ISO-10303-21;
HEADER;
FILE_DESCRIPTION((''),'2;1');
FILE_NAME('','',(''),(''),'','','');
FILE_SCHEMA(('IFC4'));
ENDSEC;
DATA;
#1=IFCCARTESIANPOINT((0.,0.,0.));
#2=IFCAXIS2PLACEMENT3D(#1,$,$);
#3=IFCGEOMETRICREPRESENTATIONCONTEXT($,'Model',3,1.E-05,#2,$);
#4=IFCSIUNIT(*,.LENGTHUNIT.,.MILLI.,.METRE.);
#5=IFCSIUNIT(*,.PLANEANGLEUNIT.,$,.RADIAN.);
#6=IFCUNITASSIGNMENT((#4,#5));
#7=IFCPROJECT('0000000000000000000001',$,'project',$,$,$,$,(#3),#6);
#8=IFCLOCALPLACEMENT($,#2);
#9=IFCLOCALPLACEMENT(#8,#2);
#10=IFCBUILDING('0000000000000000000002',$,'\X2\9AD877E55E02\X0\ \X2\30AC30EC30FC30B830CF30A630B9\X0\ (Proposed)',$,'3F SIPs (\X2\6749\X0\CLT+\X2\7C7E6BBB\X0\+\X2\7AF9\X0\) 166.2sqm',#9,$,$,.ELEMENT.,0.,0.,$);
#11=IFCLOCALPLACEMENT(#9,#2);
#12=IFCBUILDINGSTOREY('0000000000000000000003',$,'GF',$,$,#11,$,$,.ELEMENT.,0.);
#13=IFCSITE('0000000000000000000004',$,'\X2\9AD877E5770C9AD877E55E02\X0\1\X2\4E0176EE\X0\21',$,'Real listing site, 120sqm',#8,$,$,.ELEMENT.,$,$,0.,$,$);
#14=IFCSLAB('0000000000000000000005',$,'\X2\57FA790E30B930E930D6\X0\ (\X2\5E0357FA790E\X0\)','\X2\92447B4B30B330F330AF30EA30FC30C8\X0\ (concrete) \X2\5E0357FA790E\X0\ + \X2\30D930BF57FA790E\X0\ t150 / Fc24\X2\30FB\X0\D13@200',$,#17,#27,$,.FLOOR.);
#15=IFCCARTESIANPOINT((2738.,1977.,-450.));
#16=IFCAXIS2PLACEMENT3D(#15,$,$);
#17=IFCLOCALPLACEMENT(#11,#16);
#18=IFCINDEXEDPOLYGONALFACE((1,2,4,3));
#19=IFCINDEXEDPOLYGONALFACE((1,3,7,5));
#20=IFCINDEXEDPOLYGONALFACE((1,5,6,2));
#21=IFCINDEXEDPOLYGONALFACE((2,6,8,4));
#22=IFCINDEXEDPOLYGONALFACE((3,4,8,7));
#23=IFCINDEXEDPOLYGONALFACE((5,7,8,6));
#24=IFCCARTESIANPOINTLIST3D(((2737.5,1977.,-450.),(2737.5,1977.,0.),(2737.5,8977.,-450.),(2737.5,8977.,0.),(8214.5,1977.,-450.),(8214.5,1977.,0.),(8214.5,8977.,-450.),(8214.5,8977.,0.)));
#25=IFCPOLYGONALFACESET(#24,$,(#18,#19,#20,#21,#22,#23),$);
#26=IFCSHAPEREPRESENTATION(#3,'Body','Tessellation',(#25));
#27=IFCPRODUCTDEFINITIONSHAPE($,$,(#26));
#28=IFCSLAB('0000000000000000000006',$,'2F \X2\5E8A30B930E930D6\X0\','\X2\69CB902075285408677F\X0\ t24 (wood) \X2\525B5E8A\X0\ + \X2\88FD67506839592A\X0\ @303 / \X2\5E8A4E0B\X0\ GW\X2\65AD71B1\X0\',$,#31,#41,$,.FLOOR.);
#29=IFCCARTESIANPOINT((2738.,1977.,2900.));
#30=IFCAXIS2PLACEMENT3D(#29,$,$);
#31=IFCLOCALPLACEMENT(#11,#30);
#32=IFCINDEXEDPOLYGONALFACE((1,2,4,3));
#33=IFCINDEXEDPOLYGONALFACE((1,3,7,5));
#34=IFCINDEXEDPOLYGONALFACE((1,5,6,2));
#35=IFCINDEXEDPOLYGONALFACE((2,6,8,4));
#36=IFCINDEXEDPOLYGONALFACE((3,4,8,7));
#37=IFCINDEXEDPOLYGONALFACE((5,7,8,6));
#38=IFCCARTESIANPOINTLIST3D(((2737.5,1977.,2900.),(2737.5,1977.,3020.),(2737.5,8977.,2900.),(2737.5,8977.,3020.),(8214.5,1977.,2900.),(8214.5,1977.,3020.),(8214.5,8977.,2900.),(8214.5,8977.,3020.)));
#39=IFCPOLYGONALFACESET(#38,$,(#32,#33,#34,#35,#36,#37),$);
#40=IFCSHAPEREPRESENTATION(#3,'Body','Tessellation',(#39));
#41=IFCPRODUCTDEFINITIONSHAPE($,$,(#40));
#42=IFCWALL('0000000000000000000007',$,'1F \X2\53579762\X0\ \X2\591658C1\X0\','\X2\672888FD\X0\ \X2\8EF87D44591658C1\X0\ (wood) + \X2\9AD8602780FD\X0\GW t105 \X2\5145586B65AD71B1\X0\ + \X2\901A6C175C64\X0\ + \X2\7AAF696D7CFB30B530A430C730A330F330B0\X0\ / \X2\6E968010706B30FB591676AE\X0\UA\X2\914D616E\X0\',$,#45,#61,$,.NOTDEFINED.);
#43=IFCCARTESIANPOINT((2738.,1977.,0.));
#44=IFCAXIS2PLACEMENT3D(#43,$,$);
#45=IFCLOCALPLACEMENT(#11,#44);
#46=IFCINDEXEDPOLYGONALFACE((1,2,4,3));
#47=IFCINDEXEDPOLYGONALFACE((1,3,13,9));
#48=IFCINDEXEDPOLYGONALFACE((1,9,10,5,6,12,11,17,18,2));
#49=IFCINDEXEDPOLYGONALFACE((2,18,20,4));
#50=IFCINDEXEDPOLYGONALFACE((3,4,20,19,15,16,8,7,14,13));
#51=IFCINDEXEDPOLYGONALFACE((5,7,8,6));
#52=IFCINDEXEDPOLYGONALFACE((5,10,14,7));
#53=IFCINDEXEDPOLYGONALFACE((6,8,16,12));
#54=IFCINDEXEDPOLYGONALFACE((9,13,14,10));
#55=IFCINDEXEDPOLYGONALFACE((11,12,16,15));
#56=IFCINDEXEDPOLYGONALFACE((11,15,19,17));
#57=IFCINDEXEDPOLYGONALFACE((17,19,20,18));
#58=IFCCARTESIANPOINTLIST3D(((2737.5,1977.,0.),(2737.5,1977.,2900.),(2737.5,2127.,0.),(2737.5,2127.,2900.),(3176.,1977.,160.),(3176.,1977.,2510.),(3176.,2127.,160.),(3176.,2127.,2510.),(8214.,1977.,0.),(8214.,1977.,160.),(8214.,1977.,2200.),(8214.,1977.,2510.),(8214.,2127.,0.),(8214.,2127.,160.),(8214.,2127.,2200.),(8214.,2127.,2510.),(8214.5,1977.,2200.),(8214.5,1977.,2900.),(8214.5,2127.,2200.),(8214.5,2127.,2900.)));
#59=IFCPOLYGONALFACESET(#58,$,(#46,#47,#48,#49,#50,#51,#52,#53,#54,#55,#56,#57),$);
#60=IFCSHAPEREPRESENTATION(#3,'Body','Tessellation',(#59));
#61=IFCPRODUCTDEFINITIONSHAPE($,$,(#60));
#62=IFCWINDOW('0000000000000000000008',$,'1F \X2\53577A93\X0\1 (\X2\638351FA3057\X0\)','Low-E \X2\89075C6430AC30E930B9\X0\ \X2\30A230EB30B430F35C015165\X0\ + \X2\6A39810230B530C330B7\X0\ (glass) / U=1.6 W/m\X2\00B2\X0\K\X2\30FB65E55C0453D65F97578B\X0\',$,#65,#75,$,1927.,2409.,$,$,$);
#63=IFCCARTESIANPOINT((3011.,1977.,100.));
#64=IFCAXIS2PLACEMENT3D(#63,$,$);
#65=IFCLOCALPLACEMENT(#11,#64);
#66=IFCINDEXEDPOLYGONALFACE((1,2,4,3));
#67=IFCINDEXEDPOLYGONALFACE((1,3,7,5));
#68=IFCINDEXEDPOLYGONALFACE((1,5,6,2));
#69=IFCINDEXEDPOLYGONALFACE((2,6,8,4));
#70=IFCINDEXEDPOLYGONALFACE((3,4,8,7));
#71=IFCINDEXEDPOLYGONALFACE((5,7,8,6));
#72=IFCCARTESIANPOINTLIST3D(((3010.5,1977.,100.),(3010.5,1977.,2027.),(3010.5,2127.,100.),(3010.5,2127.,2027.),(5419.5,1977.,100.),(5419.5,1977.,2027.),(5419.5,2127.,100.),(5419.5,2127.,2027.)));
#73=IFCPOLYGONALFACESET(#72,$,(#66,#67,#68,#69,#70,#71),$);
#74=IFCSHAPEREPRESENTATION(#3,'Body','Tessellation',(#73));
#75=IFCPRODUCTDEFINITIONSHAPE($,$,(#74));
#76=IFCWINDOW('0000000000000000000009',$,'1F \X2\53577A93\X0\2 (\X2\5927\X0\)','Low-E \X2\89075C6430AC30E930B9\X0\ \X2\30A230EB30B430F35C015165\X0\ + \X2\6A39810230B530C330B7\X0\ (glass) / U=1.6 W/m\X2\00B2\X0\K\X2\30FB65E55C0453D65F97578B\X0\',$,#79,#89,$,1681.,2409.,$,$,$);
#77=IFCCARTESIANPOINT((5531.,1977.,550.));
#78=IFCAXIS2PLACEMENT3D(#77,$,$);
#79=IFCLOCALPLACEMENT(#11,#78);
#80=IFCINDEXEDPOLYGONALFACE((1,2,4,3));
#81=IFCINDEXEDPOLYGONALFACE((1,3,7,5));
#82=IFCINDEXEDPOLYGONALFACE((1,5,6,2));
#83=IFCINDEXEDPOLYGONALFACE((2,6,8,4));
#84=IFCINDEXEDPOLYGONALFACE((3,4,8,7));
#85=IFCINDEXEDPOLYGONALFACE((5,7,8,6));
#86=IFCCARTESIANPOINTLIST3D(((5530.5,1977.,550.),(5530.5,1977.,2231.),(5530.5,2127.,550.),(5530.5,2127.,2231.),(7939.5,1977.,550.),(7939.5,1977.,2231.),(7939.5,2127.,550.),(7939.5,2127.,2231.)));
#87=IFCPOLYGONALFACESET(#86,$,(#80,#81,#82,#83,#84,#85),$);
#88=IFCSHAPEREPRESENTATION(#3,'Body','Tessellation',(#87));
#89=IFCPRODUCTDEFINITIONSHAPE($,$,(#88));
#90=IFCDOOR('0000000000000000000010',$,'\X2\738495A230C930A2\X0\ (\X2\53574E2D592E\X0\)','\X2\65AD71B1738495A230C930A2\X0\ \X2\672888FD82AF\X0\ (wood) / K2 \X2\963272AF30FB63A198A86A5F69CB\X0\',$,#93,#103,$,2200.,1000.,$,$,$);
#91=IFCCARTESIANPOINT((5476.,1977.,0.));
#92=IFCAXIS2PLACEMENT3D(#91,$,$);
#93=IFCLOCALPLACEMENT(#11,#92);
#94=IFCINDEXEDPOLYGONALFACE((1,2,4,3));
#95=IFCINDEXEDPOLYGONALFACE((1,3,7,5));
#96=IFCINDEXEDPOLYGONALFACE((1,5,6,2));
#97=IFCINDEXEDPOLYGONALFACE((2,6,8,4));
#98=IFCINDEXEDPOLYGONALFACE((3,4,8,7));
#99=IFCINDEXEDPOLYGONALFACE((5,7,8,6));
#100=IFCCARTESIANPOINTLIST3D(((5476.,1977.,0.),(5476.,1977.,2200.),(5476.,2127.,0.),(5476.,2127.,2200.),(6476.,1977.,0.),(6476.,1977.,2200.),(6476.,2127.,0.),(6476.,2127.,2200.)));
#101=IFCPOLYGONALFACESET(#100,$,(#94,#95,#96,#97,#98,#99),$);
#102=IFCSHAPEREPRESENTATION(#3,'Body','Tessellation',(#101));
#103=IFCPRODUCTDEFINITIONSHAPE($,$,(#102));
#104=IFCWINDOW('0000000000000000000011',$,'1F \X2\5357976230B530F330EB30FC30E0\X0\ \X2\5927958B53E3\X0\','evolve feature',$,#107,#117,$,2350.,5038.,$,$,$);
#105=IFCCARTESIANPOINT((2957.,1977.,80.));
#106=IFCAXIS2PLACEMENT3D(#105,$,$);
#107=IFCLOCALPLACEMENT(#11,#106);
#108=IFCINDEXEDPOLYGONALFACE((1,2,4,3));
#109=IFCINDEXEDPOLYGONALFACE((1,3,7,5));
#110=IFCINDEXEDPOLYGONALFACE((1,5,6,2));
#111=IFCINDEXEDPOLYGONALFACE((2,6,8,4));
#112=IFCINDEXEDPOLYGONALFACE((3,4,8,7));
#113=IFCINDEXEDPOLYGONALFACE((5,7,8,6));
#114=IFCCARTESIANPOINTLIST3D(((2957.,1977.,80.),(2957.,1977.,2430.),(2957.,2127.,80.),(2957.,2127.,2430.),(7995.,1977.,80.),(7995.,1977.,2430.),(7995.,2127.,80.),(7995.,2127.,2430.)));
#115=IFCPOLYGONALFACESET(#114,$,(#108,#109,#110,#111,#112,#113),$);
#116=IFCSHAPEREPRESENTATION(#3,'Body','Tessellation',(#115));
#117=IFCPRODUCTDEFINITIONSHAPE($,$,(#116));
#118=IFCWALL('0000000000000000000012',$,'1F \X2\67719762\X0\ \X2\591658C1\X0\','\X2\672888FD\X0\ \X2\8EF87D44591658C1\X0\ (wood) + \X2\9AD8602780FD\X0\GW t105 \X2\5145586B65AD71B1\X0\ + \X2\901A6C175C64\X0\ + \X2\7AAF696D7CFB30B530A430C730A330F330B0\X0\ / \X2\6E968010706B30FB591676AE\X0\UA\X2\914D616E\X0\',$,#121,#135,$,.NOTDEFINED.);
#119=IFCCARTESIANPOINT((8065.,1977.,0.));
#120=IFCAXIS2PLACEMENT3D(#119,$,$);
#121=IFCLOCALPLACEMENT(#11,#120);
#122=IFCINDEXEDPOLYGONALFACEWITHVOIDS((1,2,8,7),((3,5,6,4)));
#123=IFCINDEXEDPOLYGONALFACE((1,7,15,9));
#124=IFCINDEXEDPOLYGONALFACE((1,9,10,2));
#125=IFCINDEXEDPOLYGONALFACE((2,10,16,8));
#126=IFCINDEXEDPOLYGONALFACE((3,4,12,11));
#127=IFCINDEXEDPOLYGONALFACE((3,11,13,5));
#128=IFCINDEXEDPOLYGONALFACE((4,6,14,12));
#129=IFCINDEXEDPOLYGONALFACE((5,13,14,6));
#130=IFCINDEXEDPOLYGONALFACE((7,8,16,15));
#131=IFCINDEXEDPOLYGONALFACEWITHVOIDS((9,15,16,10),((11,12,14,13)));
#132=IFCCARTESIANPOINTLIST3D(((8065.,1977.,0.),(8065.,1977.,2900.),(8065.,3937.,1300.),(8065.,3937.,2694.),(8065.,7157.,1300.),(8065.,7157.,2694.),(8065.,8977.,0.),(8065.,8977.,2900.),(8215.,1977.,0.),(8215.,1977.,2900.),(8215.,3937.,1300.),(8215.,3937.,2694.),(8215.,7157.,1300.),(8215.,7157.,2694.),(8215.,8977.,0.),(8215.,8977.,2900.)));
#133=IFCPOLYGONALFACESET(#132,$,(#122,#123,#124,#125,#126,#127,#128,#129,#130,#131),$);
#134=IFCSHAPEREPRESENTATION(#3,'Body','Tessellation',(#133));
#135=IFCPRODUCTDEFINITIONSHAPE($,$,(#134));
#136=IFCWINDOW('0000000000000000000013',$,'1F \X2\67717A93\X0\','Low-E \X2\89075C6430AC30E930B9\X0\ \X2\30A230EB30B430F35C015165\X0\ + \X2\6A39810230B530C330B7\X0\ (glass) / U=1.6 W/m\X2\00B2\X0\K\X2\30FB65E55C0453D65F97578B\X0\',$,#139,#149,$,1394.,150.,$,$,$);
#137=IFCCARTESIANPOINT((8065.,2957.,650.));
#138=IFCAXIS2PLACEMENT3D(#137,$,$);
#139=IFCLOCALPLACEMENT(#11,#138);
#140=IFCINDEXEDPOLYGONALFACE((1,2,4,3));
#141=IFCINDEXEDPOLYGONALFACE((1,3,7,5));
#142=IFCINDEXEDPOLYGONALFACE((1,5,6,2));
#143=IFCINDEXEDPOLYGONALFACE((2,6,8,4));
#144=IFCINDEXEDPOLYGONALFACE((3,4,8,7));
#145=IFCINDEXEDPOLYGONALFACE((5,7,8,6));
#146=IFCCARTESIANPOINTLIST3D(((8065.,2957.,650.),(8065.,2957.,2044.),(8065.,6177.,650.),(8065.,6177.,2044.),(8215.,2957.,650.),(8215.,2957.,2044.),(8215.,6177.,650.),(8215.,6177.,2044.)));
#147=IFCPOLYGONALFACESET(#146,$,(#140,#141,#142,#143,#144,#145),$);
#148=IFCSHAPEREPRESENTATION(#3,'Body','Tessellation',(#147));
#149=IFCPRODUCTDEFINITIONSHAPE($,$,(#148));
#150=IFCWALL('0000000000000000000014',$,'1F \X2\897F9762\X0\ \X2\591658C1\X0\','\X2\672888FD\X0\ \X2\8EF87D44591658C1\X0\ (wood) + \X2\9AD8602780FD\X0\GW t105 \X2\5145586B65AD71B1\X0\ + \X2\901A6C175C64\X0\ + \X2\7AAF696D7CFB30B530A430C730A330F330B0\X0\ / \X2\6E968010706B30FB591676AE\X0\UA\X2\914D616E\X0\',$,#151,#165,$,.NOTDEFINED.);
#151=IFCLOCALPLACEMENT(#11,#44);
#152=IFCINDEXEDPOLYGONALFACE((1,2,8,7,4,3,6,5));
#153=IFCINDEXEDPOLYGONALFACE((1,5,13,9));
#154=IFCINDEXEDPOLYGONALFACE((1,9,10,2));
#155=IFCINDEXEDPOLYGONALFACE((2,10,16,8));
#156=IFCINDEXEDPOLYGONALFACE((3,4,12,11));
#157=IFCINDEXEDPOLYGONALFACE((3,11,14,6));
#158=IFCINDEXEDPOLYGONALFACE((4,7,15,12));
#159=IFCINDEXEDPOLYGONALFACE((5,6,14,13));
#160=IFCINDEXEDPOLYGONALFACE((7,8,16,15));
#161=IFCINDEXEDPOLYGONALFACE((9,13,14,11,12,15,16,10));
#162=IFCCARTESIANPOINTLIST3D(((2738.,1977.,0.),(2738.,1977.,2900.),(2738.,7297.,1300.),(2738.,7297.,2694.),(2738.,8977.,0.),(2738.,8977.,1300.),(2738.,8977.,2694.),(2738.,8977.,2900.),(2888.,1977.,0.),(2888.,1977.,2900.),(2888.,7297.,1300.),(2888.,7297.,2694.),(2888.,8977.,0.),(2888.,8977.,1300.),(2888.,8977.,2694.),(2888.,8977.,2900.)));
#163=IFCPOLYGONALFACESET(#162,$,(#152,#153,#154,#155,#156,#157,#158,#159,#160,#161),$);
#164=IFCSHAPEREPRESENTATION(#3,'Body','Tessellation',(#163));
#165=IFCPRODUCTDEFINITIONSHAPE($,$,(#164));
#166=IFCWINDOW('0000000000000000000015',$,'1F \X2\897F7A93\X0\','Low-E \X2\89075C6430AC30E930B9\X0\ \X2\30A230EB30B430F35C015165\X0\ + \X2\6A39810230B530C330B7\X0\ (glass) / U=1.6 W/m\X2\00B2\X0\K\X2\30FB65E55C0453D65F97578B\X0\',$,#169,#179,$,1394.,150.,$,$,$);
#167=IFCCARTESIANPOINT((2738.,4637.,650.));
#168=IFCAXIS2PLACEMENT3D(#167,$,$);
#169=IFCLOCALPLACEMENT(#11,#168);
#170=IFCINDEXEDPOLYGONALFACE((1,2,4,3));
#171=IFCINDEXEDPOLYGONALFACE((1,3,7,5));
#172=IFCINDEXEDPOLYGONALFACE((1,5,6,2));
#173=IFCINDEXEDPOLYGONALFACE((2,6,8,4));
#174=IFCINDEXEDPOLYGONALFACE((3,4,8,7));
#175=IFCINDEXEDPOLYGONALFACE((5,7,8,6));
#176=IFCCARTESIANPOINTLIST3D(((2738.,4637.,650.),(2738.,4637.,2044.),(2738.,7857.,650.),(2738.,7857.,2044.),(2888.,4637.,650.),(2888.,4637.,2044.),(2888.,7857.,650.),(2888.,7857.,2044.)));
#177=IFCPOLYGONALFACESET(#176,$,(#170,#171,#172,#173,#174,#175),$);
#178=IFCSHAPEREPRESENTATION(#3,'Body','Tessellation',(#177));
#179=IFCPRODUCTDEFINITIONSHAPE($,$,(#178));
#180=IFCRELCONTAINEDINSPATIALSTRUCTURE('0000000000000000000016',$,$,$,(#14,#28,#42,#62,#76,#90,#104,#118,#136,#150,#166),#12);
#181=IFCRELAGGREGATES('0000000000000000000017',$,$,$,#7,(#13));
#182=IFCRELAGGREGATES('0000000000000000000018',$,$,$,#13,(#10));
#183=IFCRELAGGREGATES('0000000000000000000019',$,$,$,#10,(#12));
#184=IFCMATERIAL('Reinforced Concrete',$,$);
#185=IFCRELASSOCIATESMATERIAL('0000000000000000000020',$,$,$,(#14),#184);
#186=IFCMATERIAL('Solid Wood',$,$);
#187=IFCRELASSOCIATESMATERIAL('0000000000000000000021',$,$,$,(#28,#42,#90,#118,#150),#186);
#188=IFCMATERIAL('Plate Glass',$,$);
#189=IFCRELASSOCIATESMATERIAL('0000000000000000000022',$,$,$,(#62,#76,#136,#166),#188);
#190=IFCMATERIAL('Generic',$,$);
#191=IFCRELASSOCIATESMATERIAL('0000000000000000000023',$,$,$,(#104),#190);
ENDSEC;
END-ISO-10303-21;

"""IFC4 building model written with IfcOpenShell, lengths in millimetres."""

from ifc_helpers import new_model, si_unit, frame, frame_2d, origin, place, context, project, spatial, rectangle, extrude, material, element, fill, save


model = new_model("IFC4")

# Units and contexts
model_context = context("Model", 3, precision=1e-05, world=origin())
ifc_project = project(units=[si_unit("LENGTHUNIT", "METRE", prefix="MILLI"), si_unit("PLANEANGLEUNIT", "RADIAN")], contexts=[model_context])

# Site, building, storey
site_placement = place(None, origin())
site = spatial("IfcSite", under=ifc_project, at=site_placement, Name="高知県高知市1丁目21", ObjectType="Real listing site, 120sqm", CompositionType="ELEMENT", RefElevation=0.0)
building_placement = place(site_placement, origin())
building = spatial("IfcBuilding", under=site, at=building_placement, Name="高知市 ガレージハウス (Proposed)", ObjectType="3F SIPs (杉CLT+籾殻+竹) 166.2sqm", CompositionType="ELEMENT", ElevationOfRefHeight=0.0, ElevationOfTerrain=0.0)
storey_placement = place(building_placement, origin())
storey = spatial("IfcBuildingStorey", under=building, at=storey_placement, Name="GF", CompositionType="ELEMENT", Elevation=0.0)

# Slabs
ifc_material_1 = material(Name="Reinforced Concrete")
slab_1_placement = place(storey_placement, frame((2738.0, 1977.0, -450.0)))
element("IfcSlab", 1, at=slab_1_placement, inside=storey, material=ifc_material_1, Name="基礎スラブ (布基礎)", Description="鉄筋コンクリート (concrete) 布基礎 + ベタ基礎 t150 / Fc24・D13@200", PredefinedType="FLOOR", context=model_context, shape_type="SweptSolid", body=[
    extrude(rectangle(XDim=5477.0, YDim=7000.0, at=frame_2d((2738.0, 3500.0))), frame((2738.0, 1977.0, -450.0)), (0.0, 0.0, 1.0), 450.0),
])
ifc_material_2 = material(Name="Solid Wood")
slab_2_placement = place(storey_placement, frame((2738.0, 1977.0, 2900.0)))
element("IfcSlab", 2, at=slab_2_placement, inside=storey, material=ifc_material_2, Name="2F 床スラブ", Description="構造用合板 t24 (wood) 剛床 + 製材根太 @303 / 床下 GW断熱", PredefinedType="FLOOR", context=model_context, shape_type="SweptSolid", body=[
    extrude(rectangle(XDim=5477.0, YDim=7000.0, at=frame_2d((2738.0, 3500.0))), frame((2738.0, 1977.0, 2900.0)), (0.0, 0.0, 1.0), 120.0),
])
ifc_material_3 = material(Name="Generic")

# Wall, openings, windows, door
wall_1_placement = place(storey_placement, frame((2738.0, 1977.0, 0.0)))
wall_1 = element("IfcWall", 3, at=wall_1_placement, inside=storey, material=ifc_material_2, Name="1F 南面 外壁", Description="木製 軸組外壁 (wood) + 高性能GW t105 充填断熱 + 通気層 + 窯業系サイディング / 準耐火・外皮UA配慮", PredefinedType="NOTDEFINED", context=model_context, shape_type="SweptSolid", body=[
    extrude(rectangle(XDim=5477.0, YDim=150.0, at=frame_2d((2738.0, 75.0))), frame((2738.0, 1977.0, 0.0)), (0.0, 0.0, 1.0), 2900.0),
])
opening_1_placement = place(storey_placement, frame((3011.0, 1977.0, 100.0)))
opening_1 = element("IfcOpeningElement", 4, at=opening_1_placement, cuts=wall_1, PredefinedType="NOTDEFINED", context=model_context, shape_type="SweptSolid", body=[
    extrude(rectangle(XDim=2409.0, YDim=150.0, at=frame_2d((1204.0, 75.0))), frame((3011.0, 1977.0, 100.0)), (0.0, 0.0, 1.0), 1927.0),
])
opening_2_placement = place(storey_placement, frame((5531.0, 1977.0, 550.0)))
opening_2 = element("IfcOpeningElement", 5, at=opening_2_placement, cuts=wall_1, PredefinedType="NOTDEFINED", context=model_context, shape_type="SweptSolid", body=[
    extrude(rectangle(XDim=2409.0, YDim=150.0, at=frame_2d((1204.0, 75.0))), frame((5531.0, 1977.0, 550.0)), (0.0, 0.0, 1.0), 1681.0),
])
opening_3_placement = place(storey_placement, frame((5476.0, 1977.0, 0.0)))
opening_3 = element("IfcOpeningElement", 6, at=opening_3_placement, cuts=wall_1, PredefinedType="NOTDEFINED", context=model_context, shape_type="SweptSolid", body=[
    extrude(rectangle(XDim=1000.0, YDim=150.0, at=frame_2d((500.0, 75.0))), frame((5476.0, 1977.0, 0.0)), (0.0, 0.0, 1.0), 2200.0),
])
opening_4_placement = place(storey_placement, frame((2957.0, 1977.0, 80.0)))
opening_4 = element("IfcOpeningElement", 7, at=opening_4_placement, cuts=wall_1, PredefinedType="NOTDEFINED", context=model_context, shape_type="SweptSolid", body=[
    extrude(rectangle(XDim=5038.0, YDim=150.0, at=frame_2d((2519.0, 75.0))), frame((2957.0, 1977.0, 80.0)), (0.0, 0.0, 1.0), 2350.0),
])
ifc_material_4 = material(Name="Plate Glass")
window_1_placement = place(storey_placement, frame((3011.0, 1977.0, 100.0)))
window_1 = element("IfcWindow", 8, at=window_1_placement, inside=storey, material=ifc_material_4, Name="1F 南窓1 (掃出し)", Description="Low-E 複層ガラス アルゴン封入 + 樹脂サッシ (glass) / U=1.6 W/m²K・日射取得型", OverallHeight=1927.0, OverallWidth=2409.0, context=model_context, shape_type="SweptSolid", body=[
    extrude(rectangle(XDim=2409.0, YDim=150.0, at=frame_2d((1204.0, 75.0))), frame((3011.0, 1977.0, 100.0)), (0.0, 0.0, 1.0), 1927.0),
])
fill(opening_1, window_1)
window_2_placement = place(storey_placement, frame((5531.0, 1977.0, 550.0)))
window_2 = element("IfcWindow", 9, at=window_2_placement, inside=storey, material=ifc_material_4, Name="1F 南窓2 (大)", Description="Low-E 複層ガラス アルゴン封入 + 樹脂サッシ (glass) / U=1.6 W/m²K・日射取得型", OverallHeight=1681.0, OverallWidth=2409.0, context=model_context, shape_type="SweptSolid", body=[
    extrude(rectangle(XDim=2409.0, YDim=150.0, at=frame_2d((1204.0, 75.0))), frame((5531.0, 1977.0, 550.0)), (0.0, 0.0, 1.0), 1681.0),
])
fill(opening_2, window_2)
door_placement = place(storey_placement, frame((5476.0, 1977.0, 0.0)))
door = element("IfcDoor", 10, at=door_placement, inside=storey, material=ifc_material_2, Name="玄関ドア (南中央)", Description="断熱玄関ドア 木製芯 (wood) / K2 防犯・採風機構", OverallHeight=2200.0, OverallWidth=1000.0, context=model_context, shape_type="SweptSolid", body=[
    extrude(rectangle(XDim=1000.0, YDim=150.0, at=frame_2d((500.0, 75.0))), frame((5476.0, 1977.0, 0.0)), (0.0, 0.0, 1.0), 2200.0),
])
fill(opening_3, door)
window_3_placement = place(storey_placement, frame((2957.0, 1977.0, 80.0)))
window_3 = element("IfcWindow", 11, at=window_3_placement, inside=storey, material=ifc_material_3, Name="1F 南面サンルーム 大開口", Description="evolve feature", OverallHeight=2350.0, OverallWidth=5038.0, context=model_context, shape_type="SweptSolid", body=[
    extrude(rectangle(XDim=5038.0, YDim=150.0, at=frame_2d((2519.0, 75.0))), frame((2957.0, 1977.0, 80.0)), (0.0, 0.0, 1.0), 2350.0),
])
fill(opening_4, window_3)

# Walls, openings, windows
wall_2_placement = place(storey_placement, frame((8065.0, 1977.0, 0.0)))
wall_2 = element("IfcWall", 12, at=wall_2_placement, inside=storey, material=ifc_material_2, Name="1F 東面 外壁", Description="木製 軸組外壁 (wood) + 高性能GW t105 充填断熱 + 通気層 + 窯業系サイディング / 準耐火・外皮UA配慮", PredefinedType="NOTDEFINED", context=model_context, shape_type="SweptSolid", body=[
    extrude(rectangle(XDim=150.0, YDim=7000.0, at=frame_2d((75.0, 3500.0))), frame((8065.0, 1977.0, 0.0)), (0.0, 0.0, 1.0), 2900.0),
])
opening_5_placement = place(storey_placement, frame((8065.0, 2957.0, 650.0)))
opening_5 = element("IfcOpeningElement", 13, at=opening_5_placement, cuts=wall_2, PredefinedType="NOTDEFINED", context=model_context, shape_type="SweptSolid", body=[
    extrude(rectangle(XDim=150.0, YDim=3220.0, at=frame_2d((75.0, 1610.0))), frame((8065.0, 2957.0, 650.0)), (0.0, 0.0, 1.0), 1394.0),
])
window_4_placement = place(storey_placement, frame((8065.0, 2957.0, 650.0)))
window_4 = element("IfcWindow", 14, at=window_4_placement, inside=storey, material=ifc_material_4, Name="1F 東窓", Description="Low-E 複層ガラス アルゴン封入 + 樹脂サッシ (glass) / U=1.6 W/m²K・日射取得型", OverallHeight=1394.0, OverallWidth=150.0, context=model_context, shape_type="SweptSolid", body=[
    extrude(rectangle(XDim=150.0, YDim=3220.0, at=frame_2d((75.0, 1610.0))), frame((8065.0, 2957.0, 650.0)), (0.0, 0.0, 1.0), 1394.0),
])
fill(opening_5, window_4)
wall_3_placement = place(storey_placement, frame((2738.0, 1977.0, 0.0)))
wall_3 = element("IfcWall", 15, at=wall_3_placement, inside=storey, material=ifc_material_2, Name="1F 西面 外壁", Description="木製 軸組外壁 (wood) + 高性能GW t105 充填断熱 + 通気層 + 窯業系サイディング / 準耐火・外皮UA配慮", PredefinedType="NOTDEFINED", context=model_context, shape_type="SweptSolid", body=[
    extrude(rectangle(XDim=150.0, YDim=7000.0, at=frame_2d((75.0, 3500.0))), frame((2738.0, 1977.0, 0.0)), (0.0, 0.0, 1.0), 2900.0),
])
opening_6_placement = place(storey_placement, frame((2738.0, 4637.0, 650.0)))
opening_6 = element("IfcOpeningElement", 16, at=opening_6_placement, cuts=wall_3, PredefinedType="NOTDEFINED", context=model_context, shape_type="SweptSolid", body=[
    extrude(rectangle(XDim=150.0, YDim=3220.0, at=frame_2d((75.0, 1610.0))), frame((2738.0, 4637.0, 650.0)), (0.0, 0.0, 1.0), 1394.0),
])
window_5_placement = place(storey_placement, frame((2738.0, 4637.0, 650.0)))
window_5 = element("IfcWindow", 17, at=window_5_placement, inside=storey, material=ifc_material_4, Name="1F 西窓", Description="Low-E 複層ガラス アルゴン封入 + 樹脂サッシ (glass) / U=1.6 W/m²K・日射取得型", OverallHeight=1394.0, OverallWidth=150.0, context=model_context, shape_type="SweptSolid", body=[
    extrude(rectangle(XDim=150.0, YDim=3220.0, at=frame_2d((75.0, 1610.0))), frame((2738.0, 4637.0, 650.0)), (0.0, 0.0, 1.0), 1394.0),
])
fill(opening_6, window_5)

save(model, "model.ifc")
